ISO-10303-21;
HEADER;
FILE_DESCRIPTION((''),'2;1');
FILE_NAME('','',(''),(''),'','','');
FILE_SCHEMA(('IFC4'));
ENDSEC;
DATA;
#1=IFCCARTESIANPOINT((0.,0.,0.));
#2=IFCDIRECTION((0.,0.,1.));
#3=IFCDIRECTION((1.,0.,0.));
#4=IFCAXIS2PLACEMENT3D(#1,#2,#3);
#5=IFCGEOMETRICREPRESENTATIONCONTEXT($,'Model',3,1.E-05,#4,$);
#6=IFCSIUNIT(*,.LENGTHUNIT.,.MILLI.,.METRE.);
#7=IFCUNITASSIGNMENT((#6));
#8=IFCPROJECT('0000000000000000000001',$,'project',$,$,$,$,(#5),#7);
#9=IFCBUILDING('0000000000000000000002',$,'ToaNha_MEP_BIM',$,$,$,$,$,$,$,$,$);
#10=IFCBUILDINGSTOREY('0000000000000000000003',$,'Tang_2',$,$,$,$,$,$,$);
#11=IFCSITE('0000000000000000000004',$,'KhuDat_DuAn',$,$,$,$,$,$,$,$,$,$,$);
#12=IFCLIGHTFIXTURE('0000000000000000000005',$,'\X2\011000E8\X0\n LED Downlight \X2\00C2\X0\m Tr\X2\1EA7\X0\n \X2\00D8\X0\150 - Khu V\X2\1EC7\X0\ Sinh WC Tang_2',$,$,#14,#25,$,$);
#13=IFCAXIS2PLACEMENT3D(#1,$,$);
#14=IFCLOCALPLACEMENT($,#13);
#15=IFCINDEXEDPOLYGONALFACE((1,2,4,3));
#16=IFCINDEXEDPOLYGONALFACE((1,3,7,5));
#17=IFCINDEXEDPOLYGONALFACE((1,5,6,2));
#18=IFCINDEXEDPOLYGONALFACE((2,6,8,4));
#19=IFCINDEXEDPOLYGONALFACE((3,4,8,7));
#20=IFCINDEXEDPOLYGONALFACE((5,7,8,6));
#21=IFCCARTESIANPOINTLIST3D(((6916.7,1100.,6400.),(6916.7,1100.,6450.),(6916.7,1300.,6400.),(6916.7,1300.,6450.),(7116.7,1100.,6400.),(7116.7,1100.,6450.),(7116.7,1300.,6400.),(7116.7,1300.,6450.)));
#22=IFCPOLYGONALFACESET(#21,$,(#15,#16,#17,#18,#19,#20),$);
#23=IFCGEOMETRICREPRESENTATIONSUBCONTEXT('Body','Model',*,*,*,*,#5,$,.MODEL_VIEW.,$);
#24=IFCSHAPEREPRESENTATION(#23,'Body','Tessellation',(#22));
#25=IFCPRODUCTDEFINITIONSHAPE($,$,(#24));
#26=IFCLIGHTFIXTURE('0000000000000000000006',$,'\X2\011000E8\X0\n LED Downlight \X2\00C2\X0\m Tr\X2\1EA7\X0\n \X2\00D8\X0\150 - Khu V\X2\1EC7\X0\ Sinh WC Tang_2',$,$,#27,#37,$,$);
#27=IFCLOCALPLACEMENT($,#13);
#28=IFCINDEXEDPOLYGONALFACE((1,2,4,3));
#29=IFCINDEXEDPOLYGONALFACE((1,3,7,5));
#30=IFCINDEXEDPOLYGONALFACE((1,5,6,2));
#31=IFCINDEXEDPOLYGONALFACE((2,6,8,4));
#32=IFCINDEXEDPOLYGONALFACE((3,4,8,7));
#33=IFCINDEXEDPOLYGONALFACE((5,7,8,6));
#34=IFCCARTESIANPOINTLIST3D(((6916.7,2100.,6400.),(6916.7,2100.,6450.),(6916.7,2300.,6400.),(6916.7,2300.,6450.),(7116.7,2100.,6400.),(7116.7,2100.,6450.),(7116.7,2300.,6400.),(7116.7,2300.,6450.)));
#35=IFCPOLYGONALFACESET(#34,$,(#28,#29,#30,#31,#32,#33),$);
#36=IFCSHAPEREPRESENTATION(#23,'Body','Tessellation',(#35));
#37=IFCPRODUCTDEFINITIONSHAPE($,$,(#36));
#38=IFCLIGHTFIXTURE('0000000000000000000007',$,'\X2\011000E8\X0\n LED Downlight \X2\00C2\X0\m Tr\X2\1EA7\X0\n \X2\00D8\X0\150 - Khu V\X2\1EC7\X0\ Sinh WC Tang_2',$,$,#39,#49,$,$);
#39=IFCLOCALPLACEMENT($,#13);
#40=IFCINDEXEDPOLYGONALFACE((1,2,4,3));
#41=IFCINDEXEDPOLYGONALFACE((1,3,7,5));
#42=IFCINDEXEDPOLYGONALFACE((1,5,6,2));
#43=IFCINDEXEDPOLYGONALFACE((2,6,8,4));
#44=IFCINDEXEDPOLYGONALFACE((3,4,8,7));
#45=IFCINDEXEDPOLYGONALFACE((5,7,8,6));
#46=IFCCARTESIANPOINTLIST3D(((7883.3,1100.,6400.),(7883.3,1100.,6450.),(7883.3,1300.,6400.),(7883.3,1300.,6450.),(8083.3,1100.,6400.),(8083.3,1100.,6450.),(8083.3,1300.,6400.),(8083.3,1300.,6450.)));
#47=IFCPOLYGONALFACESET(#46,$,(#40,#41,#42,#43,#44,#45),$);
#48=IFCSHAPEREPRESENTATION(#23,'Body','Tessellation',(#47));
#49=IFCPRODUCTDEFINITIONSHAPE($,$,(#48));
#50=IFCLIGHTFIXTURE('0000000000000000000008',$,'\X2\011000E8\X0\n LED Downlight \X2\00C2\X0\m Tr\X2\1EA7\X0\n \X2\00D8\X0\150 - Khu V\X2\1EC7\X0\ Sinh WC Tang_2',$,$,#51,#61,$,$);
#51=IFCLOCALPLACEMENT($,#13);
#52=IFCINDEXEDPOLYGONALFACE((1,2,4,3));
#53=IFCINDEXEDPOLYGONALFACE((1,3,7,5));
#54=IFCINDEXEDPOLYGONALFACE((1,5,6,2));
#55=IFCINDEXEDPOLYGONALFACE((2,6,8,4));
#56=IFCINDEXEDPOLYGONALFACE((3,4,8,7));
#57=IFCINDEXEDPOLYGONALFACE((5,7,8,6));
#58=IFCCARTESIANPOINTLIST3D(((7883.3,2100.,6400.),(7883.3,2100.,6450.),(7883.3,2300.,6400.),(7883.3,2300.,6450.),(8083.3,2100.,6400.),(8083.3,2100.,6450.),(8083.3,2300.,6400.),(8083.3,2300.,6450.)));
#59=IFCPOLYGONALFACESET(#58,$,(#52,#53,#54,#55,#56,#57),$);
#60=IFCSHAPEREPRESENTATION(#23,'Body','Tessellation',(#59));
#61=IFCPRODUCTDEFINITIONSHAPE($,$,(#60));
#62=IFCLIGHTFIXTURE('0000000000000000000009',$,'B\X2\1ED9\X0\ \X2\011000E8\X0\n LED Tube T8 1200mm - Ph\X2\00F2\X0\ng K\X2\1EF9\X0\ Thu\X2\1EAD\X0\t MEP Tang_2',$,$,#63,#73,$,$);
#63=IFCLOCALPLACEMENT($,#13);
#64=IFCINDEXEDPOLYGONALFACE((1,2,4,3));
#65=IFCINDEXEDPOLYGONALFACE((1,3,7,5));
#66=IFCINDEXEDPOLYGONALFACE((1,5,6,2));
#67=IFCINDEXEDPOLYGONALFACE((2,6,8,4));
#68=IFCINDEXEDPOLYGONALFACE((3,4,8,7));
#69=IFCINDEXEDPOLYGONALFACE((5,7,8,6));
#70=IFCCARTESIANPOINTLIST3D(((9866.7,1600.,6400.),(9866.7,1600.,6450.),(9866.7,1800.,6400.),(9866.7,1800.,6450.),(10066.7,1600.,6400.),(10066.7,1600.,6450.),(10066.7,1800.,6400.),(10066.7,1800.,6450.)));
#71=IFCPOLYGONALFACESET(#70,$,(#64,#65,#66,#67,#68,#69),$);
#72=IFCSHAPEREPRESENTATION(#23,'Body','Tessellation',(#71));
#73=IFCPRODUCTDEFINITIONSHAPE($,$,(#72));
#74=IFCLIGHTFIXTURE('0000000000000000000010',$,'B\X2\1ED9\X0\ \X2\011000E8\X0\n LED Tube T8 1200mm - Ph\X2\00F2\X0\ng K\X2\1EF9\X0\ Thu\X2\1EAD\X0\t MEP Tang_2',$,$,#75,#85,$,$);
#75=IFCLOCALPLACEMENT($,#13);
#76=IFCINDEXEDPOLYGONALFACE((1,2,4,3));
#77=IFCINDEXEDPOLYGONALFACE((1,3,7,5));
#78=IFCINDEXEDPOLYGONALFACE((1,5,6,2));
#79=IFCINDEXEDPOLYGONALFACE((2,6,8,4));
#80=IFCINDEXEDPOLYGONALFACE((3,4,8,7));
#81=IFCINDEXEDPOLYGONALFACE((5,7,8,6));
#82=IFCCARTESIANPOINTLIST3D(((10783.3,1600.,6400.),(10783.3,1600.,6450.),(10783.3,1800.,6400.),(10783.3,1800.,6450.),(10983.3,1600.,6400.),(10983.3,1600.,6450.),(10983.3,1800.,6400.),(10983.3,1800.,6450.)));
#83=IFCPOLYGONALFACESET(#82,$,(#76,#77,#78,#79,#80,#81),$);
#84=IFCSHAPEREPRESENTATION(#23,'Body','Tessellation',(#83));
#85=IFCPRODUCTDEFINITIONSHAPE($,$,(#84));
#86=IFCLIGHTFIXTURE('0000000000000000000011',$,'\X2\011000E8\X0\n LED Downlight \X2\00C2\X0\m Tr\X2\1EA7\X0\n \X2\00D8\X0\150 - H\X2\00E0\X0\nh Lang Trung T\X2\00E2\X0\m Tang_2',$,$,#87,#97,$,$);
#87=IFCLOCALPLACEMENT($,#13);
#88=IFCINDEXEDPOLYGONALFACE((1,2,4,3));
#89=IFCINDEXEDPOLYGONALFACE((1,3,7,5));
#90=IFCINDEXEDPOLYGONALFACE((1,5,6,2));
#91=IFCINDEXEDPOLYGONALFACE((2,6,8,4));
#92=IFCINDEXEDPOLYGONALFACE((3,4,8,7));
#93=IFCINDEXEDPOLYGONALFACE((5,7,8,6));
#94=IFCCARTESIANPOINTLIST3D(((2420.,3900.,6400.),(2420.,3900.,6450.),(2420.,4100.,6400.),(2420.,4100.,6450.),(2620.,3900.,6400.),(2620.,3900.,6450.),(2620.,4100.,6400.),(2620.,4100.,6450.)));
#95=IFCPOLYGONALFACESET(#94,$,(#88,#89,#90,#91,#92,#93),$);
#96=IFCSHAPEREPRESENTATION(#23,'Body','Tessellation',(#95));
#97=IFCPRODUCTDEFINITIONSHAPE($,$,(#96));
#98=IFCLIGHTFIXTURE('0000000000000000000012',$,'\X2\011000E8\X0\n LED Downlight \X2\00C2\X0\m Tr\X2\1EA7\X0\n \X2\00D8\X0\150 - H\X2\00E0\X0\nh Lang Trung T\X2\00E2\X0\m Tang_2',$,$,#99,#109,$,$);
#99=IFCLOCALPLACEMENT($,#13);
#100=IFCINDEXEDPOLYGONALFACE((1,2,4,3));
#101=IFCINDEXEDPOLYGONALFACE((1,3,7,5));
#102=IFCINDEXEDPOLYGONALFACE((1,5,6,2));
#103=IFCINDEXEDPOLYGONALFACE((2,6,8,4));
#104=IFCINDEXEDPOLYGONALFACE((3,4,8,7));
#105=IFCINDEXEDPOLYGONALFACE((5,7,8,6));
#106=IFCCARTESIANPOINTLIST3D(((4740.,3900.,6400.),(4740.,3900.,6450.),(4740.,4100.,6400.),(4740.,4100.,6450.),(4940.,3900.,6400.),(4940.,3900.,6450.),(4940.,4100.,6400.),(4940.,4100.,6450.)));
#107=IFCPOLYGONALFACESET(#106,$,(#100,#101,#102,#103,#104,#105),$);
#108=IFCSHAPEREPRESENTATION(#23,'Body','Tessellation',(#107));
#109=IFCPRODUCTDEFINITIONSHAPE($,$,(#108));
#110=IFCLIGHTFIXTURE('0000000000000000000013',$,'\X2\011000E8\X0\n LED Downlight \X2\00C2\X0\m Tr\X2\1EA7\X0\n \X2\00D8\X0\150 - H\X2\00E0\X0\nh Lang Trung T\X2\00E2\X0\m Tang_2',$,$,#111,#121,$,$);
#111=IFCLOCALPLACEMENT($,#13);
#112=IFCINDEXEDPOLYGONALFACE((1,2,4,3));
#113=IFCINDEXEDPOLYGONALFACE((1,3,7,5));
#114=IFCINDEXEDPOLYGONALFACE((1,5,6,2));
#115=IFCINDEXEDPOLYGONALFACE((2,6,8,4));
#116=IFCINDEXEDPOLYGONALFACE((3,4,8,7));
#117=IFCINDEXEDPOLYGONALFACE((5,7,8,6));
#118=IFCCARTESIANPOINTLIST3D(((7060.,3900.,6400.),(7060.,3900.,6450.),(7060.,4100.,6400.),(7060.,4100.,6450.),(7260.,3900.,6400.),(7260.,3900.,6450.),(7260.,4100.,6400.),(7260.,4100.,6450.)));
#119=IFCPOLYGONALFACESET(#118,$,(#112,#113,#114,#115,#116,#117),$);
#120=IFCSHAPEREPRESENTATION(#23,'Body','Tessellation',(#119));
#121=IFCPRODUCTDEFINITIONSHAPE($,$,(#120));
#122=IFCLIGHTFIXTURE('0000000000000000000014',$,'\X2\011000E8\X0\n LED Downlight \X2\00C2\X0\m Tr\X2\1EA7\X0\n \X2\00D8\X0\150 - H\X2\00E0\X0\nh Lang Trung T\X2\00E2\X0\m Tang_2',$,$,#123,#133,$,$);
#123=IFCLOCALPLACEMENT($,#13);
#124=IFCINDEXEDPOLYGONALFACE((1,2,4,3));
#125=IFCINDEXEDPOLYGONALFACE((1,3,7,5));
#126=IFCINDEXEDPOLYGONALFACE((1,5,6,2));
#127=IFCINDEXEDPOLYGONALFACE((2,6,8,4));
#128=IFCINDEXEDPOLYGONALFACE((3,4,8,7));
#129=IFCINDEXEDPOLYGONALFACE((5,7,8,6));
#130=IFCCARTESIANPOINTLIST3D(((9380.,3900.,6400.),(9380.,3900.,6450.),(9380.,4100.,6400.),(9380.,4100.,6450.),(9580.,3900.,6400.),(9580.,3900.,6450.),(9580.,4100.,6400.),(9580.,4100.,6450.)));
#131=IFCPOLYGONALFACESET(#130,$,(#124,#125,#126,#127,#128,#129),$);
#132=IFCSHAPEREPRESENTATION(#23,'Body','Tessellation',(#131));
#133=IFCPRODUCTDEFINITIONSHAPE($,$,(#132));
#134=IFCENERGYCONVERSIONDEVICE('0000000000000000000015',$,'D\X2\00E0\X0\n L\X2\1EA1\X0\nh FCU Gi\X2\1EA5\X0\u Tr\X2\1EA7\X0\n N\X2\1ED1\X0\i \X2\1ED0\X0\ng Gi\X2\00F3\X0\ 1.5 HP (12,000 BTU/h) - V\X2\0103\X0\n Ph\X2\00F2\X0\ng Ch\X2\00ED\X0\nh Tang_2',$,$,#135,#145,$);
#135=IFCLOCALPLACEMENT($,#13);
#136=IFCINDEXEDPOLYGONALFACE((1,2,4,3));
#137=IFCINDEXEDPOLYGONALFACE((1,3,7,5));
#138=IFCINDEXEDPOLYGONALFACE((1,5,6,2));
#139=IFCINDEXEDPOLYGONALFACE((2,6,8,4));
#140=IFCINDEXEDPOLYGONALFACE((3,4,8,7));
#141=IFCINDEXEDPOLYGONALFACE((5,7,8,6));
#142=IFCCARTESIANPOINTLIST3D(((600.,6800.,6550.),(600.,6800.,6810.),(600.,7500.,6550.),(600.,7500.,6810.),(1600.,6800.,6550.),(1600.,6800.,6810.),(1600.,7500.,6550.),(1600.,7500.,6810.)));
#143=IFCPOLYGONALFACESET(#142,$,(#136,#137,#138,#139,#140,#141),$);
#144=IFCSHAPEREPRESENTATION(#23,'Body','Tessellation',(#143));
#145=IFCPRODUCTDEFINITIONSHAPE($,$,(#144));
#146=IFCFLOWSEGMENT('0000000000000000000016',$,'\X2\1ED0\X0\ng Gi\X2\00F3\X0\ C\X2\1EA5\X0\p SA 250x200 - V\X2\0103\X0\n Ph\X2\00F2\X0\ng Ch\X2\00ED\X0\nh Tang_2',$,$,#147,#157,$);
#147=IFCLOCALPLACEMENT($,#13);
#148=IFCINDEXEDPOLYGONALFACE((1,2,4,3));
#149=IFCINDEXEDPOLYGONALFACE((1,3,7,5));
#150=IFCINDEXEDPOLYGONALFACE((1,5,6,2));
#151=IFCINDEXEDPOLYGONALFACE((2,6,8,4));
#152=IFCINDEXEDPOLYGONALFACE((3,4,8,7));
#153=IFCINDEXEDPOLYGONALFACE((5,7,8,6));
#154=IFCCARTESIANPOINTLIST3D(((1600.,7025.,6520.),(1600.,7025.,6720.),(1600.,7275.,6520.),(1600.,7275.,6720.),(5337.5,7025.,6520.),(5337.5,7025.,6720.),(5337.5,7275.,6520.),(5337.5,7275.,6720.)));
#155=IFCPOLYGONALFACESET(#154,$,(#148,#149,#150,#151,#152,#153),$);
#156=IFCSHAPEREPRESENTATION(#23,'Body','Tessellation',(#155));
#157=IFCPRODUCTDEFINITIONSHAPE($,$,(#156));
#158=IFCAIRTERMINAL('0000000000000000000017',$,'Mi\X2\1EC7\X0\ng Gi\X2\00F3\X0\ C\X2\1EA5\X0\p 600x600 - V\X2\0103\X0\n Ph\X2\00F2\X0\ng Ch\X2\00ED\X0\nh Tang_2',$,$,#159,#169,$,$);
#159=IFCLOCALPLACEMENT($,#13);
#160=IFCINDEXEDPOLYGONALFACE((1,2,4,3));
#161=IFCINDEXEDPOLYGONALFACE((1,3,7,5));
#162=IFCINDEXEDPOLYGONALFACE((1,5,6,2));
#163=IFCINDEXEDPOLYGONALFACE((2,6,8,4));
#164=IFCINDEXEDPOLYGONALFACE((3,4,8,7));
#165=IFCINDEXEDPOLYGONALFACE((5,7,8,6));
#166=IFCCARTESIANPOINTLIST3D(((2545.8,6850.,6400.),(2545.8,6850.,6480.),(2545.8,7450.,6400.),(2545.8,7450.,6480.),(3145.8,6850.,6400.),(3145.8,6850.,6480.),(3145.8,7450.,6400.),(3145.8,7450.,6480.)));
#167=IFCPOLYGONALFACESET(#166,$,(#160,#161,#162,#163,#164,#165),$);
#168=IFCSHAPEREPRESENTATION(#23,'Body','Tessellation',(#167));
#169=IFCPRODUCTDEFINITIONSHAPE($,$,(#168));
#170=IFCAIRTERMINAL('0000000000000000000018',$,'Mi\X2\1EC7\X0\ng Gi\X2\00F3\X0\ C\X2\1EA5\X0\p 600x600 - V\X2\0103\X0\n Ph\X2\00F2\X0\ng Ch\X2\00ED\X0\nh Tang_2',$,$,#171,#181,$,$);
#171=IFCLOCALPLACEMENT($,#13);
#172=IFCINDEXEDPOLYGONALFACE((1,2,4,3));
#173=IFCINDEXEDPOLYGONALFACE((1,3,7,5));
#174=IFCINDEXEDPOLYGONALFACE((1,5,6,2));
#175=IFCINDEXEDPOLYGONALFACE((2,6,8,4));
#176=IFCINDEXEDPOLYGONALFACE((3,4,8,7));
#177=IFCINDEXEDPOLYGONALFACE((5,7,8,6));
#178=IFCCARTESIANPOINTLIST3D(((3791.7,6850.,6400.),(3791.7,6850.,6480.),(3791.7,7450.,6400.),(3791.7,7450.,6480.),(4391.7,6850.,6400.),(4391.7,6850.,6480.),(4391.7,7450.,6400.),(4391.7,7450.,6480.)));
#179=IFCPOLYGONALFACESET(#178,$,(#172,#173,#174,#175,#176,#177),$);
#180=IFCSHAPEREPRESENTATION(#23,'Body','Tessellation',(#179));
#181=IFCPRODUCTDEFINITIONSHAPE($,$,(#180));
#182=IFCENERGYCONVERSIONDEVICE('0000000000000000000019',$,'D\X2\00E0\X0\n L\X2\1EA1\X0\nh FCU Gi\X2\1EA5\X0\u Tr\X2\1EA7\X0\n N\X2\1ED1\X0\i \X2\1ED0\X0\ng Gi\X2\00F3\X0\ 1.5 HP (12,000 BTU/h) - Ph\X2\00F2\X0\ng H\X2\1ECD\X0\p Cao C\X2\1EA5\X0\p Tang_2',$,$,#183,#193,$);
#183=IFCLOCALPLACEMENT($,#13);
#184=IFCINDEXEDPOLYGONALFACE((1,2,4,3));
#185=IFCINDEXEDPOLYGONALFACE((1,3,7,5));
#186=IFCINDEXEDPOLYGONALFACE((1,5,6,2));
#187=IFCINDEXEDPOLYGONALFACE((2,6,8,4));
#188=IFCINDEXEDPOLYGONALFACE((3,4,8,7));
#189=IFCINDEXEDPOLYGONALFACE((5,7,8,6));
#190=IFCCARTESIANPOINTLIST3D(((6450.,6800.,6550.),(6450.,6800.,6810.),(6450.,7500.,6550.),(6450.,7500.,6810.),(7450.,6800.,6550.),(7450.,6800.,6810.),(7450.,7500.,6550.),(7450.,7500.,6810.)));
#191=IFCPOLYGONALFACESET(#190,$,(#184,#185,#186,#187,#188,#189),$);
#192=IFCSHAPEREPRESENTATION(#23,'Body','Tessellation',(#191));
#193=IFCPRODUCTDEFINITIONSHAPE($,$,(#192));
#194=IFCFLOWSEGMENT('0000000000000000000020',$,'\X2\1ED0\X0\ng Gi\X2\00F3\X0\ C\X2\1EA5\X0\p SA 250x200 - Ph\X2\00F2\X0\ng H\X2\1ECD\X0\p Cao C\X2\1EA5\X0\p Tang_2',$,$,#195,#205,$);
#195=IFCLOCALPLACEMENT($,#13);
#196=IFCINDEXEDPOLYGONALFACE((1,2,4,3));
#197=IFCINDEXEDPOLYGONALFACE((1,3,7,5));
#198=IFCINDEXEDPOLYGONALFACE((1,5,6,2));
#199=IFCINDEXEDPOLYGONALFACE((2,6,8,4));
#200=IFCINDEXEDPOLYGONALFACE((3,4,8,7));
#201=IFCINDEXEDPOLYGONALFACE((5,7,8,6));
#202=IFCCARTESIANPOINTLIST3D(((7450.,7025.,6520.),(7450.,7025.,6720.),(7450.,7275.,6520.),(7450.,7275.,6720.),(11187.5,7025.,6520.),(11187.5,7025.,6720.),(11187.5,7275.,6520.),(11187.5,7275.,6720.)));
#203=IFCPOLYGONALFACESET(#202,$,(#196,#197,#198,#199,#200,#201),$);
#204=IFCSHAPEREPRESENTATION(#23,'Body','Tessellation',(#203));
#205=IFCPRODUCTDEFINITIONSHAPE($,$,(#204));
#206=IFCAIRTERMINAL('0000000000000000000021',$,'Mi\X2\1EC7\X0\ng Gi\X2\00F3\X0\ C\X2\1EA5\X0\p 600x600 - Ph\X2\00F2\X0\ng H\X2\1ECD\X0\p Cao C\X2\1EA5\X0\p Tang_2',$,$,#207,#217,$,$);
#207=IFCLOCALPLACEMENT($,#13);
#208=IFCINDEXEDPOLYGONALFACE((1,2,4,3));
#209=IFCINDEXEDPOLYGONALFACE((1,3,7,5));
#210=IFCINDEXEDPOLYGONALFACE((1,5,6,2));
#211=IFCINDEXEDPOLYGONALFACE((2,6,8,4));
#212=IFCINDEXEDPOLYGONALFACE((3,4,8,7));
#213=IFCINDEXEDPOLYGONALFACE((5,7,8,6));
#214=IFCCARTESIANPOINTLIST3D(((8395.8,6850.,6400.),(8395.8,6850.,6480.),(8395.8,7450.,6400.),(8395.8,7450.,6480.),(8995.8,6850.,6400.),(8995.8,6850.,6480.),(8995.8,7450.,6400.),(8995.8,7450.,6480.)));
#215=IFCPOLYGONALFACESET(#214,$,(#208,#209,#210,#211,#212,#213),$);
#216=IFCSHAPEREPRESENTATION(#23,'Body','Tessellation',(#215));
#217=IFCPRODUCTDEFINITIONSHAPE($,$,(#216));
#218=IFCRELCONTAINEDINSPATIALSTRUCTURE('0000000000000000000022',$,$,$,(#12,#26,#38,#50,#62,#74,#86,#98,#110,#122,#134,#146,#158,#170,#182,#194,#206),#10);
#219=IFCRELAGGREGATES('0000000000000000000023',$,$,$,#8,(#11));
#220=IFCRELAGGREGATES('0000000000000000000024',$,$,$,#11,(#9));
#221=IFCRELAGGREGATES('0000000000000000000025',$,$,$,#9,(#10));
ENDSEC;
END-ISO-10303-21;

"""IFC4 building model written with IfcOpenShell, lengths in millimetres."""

from ifc_helpers import new_model, si_unit, frame, origin_with_axes, context, subcontext, project, spatial, polyline, outline, extrude, element, save


model = new_model("IFC4")

# Units and contexts
model_context = context("Model", 3, precision=1e-05, world=origin_with_axes())
body_context = subcontext(model_context, "Body", "Model", "MODEL_VIEW")
ifc_project = project(units=[si_unit("LENGTHUNIT", "METRE", prefix="MILLI")], contexts=[model_context])

# Site, building, storey
site = spatial("IfcSite", under=ifc_project, Name="KhuDat_DuAn")
building = spatial("IfcBuilding", under=site, Name="ToaNha_MEP_BIM")
storey = spatial("IfcBuildingStorey", under=building, Name="Tang_2")

# Light fixtures
element("IfcLightFixture", 1, inside=storey, Name="Đèn LED Downlight Âm Trần Ø150 - Khu Vệ Sinh WC Tang_2", context=body_context, shape_type="SweptSolid", body=[
    extrude(outline(polyline([(6916.7, 1100.0), (7116.7, 1100.0), (7116.7, 1300.0), (6916.7, 1300.0), (6916.7, 1100.0)])), frame((0.0, 0.0, 6400.0), z_axis=(0.0, 0.0, 1.0), x_axis=(1.0, 0.0, 0.0)), (0.0, 0.0, 1.0), 50.0),
])
element("IfcLightFixture", 2, inside=storey, Name="Đèn LED Downlight Âm Trần Ø150 - Khu Vệ Sinh WC Tang_2", context=body_context, shape_type="SweptSolid", body=[
    extrude(outline(polyline([(6916.7, 2100.0), (7116.7, 2100.0), (7116.7, 2300.0), (6916.7, 2300.0), (6916.7, 2100.0)])), frame((0.0, 0.0, 6400.0), z_axis=(0.0, 0.0, 1.0), x_axis=(1.0, 0.0, 0.0)), (0.0, 0.0, 1.0), 50.0),
])
element("IfcLightFixture", 3, inside=storey, Name="Đèn LED Downlight Âm Trần Ø150 - Khu Vệ Sinh WC Tang_2", context=body_context, shape_type="SweptSolid", body=[
    extrude(outline(polyline([(7883.3, 1100.0), (8083.3, 1100.0), (8083.3, 1300.0), (7883.3, 1300.0), (7883.3, 1100.0)])), frame((0.0, 0.0, 6400.0), z_axis=(0.0, 0.0, 1.0), x_axis=(1.0, 0.0, 0.0)), (0.0, 0.0, 1.0), 50.0),
])
element("IfcLightFixture", 4, inside=storey, Name="Đèn LED Downlight Âm Trần Ø150 - Khu Vệ Sinh WC Tang_2", context=body_context, shape_type="SweptSolid", body=[
    extrude(outline(polyline([(7883.3, 2100.0), (8083.3, 2100.0), (8083.3, 2300.0), (7883.3, 2300.0), (7883.3, 2100.0)])), frame((0.0, 0.0, 6400.0), z_axis=(0.0, 0.0, 1.0), x_axis=(1.0, 0.0, 0.0)), (0.0, 0.0, 1.0), 50.0),
])
element("IfcLightFixture", 5, inside=storey, Name="Bộ Đèn LED Tube T8 1200mm - Phòng Kỹ Thuật MEP Tang_2", context=body_context, shape_type="SweptSolid", body=[
    extrude(outline(polyline([(9866.7, 1600.0), (10066.7, 1600.0), (10066.7, 1800.0), (9866.7, 1800.0), (9866.7, 1600.0)])), frame((0.0, 0.0, 6400.0), z_axis=(0.0, 0.0, 1.0), x_axis=(1.0, 0.0, 0.0)), (0.0, 0.0, 1.0), 50.0),
])
element("IfcLightFixture", 6, inside=storey, Name="Bộ Đèn LED Tube T8 1200mm - Phòng Kỹ Thuật MEP Tang_2", context=body_context, shape_type="SweptSolid", body=[
    extrude(outline(polyline([(10783.3, 1600.0), (10983.3, 1600.0), (10983.3, 1800.0), (10783.3, 1800.0), (10783.3, 1600.0)])), frame((0.0, 0.0, 6400.0), z_axis=(0.0, 0.0, 1.0), x_axis=(1.0, 0.0, 0.0)), (0.0, 0.0, 1.0), 50.0),
])
element("IfcLightFixture", 7, inside=storey, Name="Đèn LED Downlight Âm Trần Ø150 - Hành Lang Trung Tâm Tang_2", context=body_context, shape_type="SweptSolid", body=[
    extrude(outline(polyline([(2420.0, 3900.0), (2620.0, 3900.0), (2620.0, 4100.0), (2420.0, 4100.0), (2420.0, 3900.0)])), frame((0.0, 0.0, 6400.0), z_axis=(0.0, 0.0, 1.0), x_axis=(1.0, 0.0, 0.0)), (0.0, 0.0, 1.0), 50.0),
])
element("IfcLightFixture", 8, inside=storey, Name="Đèn LED Downlight Âm Trần Ø150 - Hành Lang Trung Tâm Tang_2", context=body_context, shape_type="SweptSolid", body=[
    extrude(outline(polyline([(4740.0, 3900.0), (4940.0, 3900.0), (4940.0, 4100.0), (4740.0, 4100.0), (4740.0, 3900.0)])), frame((0.0, 0.0, 6400.0), z_axis=(0.0, 0.0, 1.0), x_axis=(1.0, 0.0, 0.0)), (0.0, 0.0, 1.0), 50.0),
])
element("IfcLightFixture", 9, inside=storey, Name="Đèn LED Downlight Âm Trần Ø150 - Hành Lang Trung Tâm Tang_2", context=body_context, shape_type="SweptSolid", body=[
    extrude(outline(polyline([(7060.0, 3900.0), (7260.0, 3900.0), (7260.0, 4100.0), (7060.0, 4100.0), (7060.0, 3900.0)])), frame((0.0, 0.0, 6400.0), z_axis=(0.0, 0.0, 1.0), x_axis=(1.0, 0.0, 0.0)), (0.0, 0.0, 1.0), 50.0),
])
element("IfcLightFixture", 10, inside=storey, Name="Đèn LED Downlight Âm Trần Ø150 - Hành Lang Trung Tâm Tang_2", context=body_context, shape_type="SweptSolid", body=[
    extrude(outline(polyline([(9380.0, 3900.0), (9580.0, 3900.0), (9580.0, 4100.0), (9380.0, 4100.0), (9380.0, 3900.0)])), frame((0.0, 0.0, 6400.0), z_axis=(0.0, 0.0, 1.0), x_axis=(1.0, 0.0, 0.0)), (0.0, 0.0, 1.0), 50.0),
])

# Energy conversion device
element("IfcEnergyConversionDevice", 11, inside=storey, Name="Dàn Lạnh FCU Giấu Trần Nối Ống Gió 1.5 HP (12,000 BTU/h) - Văn Phòng Chính Tang_2", context=body_context, shape_type="SweptSolid", body=[
    extrude(outline(polyline([(600.0, 6800.0), (1600.0, 6800.0), (1600.0, 7500.0), (600.0, 7500.0), (600.0, 6800.0)])), frame((0.0, 0.0, 6550.0), z_axis=(0.0, 0.0, 1.0), x_axis=(1.0, 0.0, 0.0)), (0.0, 0.0, 1.0), 260.0),
])

# Flow segment
element("IfcFlowSegment", 12, inside=storey, Name="Ống Gió Cấp SA 250x200 - Văn Phòng Chính Tang_2", context=body_context, shape_type="SweptSolid", body=[
    extrude(outline(polyline([(1600.0, 7025.0), (5337.5, 7025.0), (5337.5, 7275.0), (1600.0, 7275.0), (1600.0, 7025.0)])), frame((0.0, 0.0, 6520.0), z_axis=(0.0, 0.0, 1.0), x_axis=(1.0, 0.0, 0.0)), (0.0, 0.0, 1.0), 200.0),
])

# Air terminals
element("IfcAirTerminal", 13, inside=storey, Name="Miệng Gió Cấp 600x600 - Văn Phòng Chính Tang_2", context=body_context, shape_type="SweptSolid", body=[
    extrude(outline(polyline([(2545.8, 6850.0), (3145.8, 6850.0), (3145.8, 7450.0), (2545.8, 7450.0), (2545.8, 6850.0)])), frame((0.0, 0.0, 6400.0), z_axis=(0.0, 0.0, 1.0), x_axis=(1.0, 0.0, 0.0)), (0.0, 0.0, 1.0), 80.0),
])
element("IfcAirTerminal", 14, inside=storey, Name="Miệng Gió Cấp 600x600 - Văn Phòng Chính Tang_2", context=body_context, shape_type="SweptSolid", body=[
    extrude(outline(polyline([(3791.7, 6850.0), (4391.7, 6850.0), (4391.7, 7450.0), (3791.7, 7450.0), (3791.7, 6850.0)])), frame((0.0, 0.0, 6400.0), z_axis=(0.0, 0.0, 1.0), x_axis=(1.0, 0.0, 0.0)), (0.0, 0.0, 1.0), 80.0),
])

# Energy conversion device
element("IfcEnergyConversionDevice", 15, inside=storey, Name="Dàn Lạnh FCU Giấu Trần Nối Ống Gió 1.5 HP (12,000 BTU/h) - Phòng Họp Cao Cấp Tang_2", context=body_context, shape_type="SweptSolid", body=[
    extrude(outline(polyline([(6450.0, 6800.0), (7450.0, 6800.0), (7450.0, 7500.0), (6450.0, 7500.0), (6450.0, 6800.0)])), frame((0.0, 0.0, 6550.0), z_axis=(0.0, 0.0, 1.0), x_axis=(1.0, 0.0, 0.0)), (0.0, 0.0, 1.0), 260.0),
])

# Flow segment
element("IfcFlowSegment", 16, inside=storey, Name="Ống Gió Cấp SA 250x200 - Phòng Họp Cao Cấp Tang_2", context=body_context, shape_type="SweptSolid", body=[
    extrude(outline(polyline([(7450.0, 7025.0), (11187.5, 7025.0), (11187.5, 7275.0), (7450.0, 7275.0), (7450.0, 7025.0)])), frame((0.0, 0.0, 6520.0), z_axis=(0.0, 0.0, 1.0), x_axis=(1.0, 0.0, 0.0)), (0.0, 0.0, 1.0), 200.0),
])

# Air terminal
element("IfcAirTerminal", 17, inside=storey, Name="Miệng Gió Cấp 600x600 - Phòng Họp Cao Cấp Tang_2", context=body_context, shape_type="SweptSolid", body=[
    extrude(outline(polyline([(8395.8, 6850.0), (8995.8, 6850.0), (8995.8, 7450.0), (8395.8, 7450.0), (8395.8, 6850.0)])), frame((0.0, 0.0, 6400.0), z_axis=(0.0, 0.0, 1.0), x_axis=(1.0, 0.0, 0.0)), (0.0, 0.0, 1.0), 80.0),
])

save(model, "model.ifc")
